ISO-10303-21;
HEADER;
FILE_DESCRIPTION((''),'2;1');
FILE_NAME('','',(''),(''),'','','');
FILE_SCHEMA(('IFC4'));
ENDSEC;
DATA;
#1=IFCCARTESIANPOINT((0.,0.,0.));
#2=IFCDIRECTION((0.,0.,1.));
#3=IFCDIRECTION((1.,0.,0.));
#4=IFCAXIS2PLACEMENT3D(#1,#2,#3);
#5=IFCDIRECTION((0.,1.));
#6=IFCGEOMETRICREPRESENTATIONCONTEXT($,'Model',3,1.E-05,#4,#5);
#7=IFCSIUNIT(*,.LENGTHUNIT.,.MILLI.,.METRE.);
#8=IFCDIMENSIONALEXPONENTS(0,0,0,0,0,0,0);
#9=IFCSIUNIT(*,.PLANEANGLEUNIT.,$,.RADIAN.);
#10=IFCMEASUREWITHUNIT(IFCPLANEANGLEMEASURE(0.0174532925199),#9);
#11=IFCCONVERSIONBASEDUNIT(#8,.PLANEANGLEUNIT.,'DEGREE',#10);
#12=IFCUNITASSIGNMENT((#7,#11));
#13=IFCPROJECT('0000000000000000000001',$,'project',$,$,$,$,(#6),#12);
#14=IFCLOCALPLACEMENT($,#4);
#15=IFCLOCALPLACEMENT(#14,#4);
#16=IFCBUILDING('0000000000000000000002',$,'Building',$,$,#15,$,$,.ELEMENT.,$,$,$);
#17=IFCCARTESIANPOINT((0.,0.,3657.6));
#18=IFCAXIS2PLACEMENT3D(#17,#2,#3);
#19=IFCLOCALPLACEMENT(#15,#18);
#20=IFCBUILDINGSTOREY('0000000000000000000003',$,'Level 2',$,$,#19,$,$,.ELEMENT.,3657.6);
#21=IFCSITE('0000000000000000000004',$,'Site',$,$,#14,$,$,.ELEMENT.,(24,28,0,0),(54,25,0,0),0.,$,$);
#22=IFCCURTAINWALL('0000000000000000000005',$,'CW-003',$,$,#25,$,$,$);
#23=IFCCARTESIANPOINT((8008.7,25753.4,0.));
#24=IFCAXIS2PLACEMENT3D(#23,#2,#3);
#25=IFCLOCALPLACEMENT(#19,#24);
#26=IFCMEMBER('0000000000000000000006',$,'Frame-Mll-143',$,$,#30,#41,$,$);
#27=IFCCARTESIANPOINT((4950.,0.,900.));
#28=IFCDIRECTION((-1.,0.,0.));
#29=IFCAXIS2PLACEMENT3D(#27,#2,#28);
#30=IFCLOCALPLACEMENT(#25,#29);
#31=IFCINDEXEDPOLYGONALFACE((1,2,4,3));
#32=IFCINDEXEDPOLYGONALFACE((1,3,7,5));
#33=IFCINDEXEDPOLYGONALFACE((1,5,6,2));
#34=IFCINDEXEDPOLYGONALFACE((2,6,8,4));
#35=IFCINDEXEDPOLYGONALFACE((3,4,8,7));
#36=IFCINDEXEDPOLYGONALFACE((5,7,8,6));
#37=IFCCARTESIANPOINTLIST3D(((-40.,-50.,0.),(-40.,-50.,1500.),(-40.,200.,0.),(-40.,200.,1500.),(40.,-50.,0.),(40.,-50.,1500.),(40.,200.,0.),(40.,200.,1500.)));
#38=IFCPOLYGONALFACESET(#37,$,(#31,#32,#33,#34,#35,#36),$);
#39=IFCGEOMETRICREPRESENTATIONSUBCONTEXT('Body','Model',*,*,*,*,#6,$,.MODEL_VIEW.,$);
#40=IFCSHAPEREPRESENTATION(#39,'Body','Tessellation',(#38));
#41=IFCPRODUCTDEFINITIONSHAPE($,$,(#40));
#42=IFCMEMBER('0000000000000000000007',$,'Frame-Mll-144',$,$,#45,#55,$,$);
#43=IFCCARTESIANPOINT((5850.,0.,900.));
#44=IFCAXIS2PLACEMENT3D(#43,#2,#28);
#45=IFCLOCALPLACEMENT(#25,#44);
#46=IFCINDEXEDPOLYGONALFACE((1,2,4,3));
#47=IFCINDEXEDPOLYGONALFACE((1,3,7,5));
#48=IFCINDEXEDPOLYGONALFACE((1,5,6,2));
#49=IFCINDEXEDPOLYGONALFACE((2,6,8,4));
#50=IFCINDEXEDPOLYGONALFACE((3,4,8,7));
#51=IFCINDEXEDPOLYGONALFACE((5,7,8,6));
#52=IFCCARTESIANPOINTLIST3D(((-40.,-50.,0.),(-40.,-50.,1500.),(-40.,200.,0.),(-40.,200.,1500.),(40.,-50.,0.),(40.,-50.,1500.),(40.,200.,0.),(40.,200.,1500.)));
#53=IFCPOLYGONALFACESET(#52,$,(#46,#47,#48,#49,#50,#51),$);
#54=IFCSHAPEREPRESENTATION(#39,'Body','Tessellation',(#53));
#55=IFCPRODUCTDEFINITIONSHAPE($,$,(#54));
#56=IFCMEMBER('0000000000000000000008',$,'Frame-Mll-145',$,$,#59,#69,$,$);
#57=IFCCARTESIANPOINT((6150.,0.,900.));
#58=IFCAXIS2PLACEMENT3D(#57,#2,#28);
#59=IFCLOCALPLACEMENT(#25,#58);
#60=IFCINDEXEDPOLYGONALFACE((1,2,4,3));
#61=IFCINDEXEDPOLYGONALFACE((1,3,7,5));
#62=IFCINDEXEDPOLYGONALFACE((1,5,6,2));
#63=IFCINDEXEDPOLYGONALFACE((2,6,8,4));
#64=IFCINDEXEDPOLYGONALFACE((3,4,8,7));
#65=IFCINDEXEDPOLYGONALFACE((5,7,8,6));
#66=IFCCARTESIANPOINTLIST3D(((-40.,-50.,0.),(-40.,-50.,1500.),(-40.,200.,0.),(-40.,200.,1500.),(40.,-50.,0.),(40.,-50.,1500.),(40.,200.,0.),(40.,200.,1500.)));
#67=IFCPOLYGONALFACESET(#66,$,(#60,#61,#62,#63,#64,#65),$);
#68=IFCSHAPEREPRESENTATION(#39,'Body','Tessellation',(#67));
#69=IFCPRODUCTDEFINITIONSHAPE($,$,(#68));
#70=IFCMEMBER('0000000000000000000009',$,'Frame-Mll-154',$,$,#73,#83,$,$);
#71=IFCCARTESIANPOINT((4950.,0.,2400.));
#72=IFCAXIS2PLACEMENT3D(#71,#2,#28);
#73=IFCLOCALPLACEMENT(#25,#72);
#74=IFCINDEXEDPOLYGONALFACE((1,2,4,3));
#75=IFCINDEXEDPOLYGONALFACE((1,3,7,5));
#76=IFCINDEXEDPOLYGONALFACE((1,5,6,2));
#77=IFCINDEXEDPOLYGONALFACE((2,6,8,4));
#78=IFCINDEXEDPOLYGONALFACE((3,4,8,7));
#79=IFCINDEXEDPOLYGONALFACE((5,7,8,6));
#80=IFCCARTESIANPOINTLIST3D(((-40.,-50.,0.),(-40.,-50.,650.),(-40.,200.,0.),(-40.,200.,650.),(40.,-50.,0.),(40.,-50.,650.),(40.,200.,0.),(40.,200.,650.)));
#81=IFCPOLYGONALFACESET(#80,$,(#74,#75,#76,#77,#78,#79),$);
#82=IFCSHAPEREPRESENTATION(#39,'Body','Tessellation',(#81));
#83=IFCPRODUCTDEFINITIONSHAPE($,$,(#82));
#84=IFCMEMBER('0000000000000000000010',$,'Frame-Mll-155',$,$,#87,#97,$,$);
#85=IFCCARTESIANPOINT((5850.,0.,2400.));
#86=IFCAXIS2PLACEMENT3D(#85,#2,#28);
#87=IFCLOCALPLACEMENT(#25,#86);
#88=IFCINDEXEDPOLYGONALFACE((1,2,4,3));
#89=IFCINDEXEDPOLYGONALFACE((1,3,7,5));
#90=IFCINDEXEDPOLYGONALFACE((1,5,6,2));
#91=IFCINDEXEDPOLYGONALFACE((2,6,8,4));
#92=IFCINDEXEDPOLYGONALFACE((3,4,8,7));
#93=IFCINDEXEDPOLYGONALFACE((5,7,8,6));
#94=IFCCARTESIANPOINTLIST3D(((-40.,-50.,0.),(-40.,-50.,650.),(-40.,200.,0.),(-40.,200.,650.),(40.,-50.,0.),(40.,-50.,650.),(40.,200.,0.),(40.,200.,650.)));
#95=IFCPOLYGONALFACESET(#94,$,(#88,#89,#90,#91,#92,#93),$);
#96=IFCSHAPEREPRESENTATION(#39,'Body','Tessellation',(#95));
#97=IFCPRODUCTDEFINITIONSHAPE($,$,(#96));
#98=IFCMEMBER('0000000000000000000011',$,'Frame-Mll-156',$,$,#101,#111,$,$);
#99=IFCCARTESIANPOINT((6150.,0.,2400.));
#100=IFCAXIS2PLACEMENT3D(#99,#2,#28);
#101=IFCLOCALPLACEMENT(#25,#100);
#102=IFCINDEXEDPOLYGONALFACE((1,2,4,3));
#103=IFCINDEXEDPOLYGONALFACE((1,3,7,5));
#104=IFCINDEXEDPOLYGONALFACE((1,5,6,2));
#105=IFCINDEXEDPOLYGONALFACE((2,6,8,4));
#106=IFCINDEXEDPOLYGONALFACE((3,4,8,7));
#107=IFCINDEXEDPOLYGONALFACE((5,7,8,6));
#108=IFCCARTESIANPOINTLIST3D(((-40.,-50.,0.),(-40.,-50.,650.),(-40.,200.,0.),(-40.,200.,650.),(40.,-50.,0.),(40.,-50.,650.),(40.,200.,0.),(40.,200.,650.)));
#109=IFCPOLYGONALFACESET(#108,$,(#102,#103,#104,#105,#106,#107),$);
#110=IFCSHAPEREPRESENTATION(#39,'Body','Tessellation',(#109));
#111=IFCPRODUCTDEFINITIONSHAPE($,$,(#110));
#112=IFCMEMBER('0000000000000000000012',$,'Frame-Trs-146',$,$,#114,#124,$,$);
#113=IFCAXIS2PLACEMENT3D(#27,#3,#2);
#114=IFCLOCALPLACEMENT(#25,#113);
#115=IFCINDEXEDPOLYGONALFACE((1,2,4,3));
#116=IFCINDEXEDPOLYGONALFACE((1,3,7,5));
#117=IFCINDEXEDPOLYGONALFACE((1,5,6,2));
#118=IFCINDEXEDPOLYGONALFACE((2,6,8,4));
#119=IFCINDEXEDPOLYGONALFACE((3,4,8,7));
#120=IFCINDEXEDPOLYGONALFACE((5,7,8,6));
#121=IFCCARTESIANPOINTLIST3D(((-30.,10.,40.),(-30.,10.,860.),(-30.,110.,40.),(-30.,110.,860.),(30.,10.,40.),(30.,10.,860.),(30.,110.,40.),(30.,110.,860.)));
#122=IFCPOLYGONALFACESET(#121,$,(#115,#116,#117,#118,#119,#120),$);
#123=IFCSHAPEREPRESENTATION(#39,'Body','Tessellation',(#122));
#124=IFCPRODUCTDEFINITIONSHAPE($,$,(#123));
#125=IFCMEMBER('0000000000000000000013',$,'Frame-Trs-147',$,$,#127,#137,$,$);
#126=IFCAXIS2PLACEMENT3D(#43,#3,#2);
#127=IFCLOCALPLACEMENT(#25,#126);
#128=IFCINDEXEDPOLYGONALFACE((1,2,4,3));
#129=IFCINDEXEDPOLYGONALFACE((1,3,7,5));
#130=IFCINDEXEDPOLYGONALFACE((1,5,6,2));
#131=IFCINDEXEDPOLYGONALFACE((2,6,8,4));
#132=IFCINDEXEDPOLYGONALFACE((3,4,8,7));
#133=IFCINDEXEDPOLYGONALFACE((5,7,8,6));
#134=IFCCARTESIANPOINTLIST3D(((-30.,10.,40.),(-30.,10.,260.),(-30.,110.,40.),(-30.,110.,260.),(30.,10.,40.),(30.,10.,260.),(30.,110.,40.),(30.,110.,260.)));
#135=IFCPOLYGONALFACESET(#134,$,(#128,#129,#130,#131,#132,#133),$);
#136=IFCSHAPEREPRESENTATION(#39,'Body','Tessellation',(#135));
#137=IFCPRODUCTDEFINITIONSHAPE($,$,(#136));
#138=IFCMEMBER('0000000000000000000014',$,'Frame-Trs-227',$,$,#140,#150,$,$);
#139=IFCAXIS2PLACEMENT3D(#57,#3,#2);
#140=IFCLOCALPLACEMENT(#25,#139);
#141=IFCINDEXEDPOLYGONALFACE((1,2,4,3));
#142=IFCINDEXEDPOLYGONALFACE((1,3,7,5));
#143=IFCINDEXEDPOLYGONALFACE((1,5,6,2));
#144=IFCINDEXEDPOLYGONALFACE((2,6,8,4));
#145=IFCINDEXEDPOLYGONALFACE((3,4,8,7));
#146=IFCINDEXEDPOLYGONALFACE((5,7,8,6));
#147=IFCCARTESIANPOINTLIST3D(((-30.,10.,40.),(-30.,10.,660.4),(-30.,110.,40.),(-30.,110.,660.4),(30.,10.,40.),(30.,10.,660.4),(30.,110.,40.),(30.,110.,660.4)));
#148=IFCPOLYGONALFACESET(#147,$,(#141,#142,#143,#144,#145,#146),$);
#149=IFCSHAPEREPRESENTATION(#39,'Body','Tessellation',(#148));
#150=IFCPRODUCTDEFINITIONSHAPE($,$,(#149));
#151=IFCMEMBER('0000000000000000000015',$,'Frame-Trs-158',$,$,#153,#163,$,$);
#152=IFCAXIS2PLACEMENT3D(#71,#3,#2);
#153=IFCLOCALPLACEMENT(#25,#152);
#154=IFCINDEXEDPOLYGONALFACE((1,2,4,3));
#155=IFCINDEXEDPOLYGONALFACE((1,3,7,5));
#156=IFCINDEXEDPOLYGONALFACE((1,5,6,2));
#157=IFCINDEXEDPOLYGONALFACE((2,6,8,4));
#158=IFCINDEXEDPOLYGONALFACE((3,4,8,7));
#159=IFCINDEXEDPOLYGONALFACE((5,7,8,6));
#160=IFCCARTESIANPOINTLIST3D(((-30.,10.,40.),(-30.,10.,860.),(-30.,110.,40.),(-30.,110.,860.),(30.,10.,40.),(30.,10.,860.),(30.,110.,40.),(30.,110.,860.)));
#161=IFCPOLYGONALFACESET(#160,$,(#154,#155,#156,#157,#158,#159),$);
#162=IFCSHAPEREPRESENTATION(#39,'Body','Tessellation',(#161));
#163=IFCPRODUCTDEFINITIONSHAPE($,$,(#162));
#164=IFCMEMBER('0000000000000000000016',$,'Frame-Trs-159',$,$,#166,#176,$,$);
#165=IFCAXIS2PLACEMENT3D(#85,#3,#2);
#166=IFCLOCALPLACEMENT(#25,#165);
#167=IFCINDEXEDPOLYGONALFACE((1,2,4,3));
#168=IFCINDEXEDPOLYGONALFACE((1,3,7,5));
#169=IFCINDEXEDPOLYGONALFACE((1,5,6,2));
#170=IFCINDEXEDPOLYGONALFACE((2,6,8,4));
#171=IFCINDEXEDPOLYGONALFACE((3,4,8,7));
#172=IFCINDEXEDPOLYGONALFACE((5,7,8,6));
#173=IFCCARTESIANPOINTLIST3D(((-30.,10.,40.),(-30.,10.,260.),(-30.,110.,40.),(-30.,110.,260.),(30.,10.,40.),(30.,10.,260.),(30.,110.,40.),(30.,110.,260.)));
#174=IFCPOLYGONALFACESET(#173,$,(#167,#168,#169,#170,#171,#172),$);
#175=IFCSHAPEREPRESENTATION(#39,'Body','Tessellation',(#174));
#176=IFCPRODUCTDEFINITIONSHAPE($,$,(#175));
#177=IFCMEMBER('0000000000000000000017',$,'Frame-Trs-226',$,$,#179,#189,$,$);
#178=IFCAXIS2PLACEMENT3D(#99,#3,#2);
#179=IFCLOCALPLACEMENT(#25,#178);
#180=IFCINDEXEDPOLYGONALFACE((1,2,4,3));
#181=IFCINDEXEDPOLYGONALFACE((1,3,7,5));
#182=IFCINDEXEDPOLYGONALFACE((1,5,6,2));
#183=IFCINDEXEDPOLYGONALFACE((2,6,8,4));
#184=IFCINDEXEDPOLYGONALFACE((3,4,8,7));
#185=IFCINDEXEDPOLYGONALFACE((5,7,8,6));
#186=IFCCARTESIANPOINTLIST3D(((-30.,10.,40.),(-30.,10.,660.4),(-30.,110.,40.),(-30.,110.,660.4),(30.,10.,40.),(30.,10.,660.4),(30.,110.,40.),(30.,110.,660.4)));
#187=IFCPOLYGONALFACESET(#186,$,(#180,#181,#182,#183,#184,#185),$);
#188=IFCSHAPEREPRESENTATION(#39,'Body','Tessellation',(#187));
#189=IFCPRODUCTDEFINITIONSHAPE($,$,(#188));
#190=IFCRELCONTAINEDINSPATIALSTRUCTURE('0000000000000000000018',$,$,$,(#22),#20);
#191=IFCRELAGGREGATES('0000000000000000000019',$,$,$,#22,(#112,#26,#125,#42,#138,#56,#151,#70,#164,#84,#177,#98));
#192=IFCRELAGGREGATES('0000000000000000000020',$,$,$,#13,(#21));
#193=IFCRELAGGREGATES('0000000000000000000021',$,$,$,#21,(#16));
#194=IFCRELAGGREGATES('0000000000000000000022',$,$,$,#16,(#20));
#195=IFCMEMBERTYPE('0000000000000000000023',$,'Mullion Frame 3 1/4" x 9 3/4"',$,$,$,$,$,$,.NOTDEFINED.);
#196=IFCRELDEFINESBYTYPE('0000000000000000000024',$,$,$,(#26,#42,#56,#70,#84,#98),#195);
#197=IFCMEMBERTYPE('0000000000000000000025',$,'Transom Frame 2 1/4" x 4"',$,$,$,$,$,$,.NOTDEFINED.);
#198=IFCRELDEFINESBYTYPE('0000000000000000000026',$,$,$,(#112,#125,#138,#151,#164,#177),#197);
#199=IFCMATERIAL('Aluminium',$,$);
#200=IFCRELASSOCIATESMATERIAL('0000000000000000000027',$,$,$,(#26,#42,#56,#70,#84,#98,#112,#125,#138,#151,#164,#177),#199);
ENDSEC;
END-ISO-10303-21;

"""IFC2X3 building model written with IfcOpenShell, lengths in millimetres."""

from ifc_helpers import new_model, entity, si_unit, converted_unit, direction, frame, origin_with_axes, place, context, subcontext, project, spatial, polyline, outline, extrude, material, type_object, element, aggregate, save


model = new_model("IFC2X3")

# Units and contexts
model_context = context("Model", 3, precision=1e-05, world=origin_with_axes(), true_north=direction((0.0, 1.0)))
body_context = subcontext(model_context, "Body", "Model", "MODEL_VIEW")
ifc_project = project(units=[si_unit("LENGTHUNIT", "METRE", prefix="MILLI"), converted_unit("PLANEANGLEUNIT", "DEGREE", entity("IfcPlaneAngleMeasure", 0.0174532925199), si_unit("PLANEANGLEUNIT", "RADIAN"), dimensions=[0, 0, 0, 0, 0, 0, 0])], contexts=[model_context])

# Site, building, storey
site_placement = place(None, origin_with_axes())
site = spatial("IfcSite", under=ifc_project, at=site_placement, Name="Site", CompositionType="ELEMENT", RefLatitude=(24, 28, 0, 0), RefLongitude=(54, 25, 0, 0), RefElevation=0.0)
building_placement = place(site_placement, origin_with_axes())
building = spatial("IfcBuilding", under=site, at=building_placement, Name="Building", CompositionType="ELEMENT")
storey_placement = place(building_placement, frame((0.0, 0.0, 3657.6), z_axis=(0.0, 0.0, 1.0), x_axis=(1.0, 0.0, 0.0)))
storey = spatial("IfcBuildingStorey", under=building, at=storey_placement, Name="Level 2", CompositionType="ELEMENT", Elevation=3657.6)

# Curtain wall, members
curtain_wall_placement = place(storey_placement, frame((8008.7, 25753.4, 0.0), z_axis=(0.0, 0.0, 1.0), x_axis=(1.0, 0.0, 0.0)))
curtain_wall = element("IfcCurtainWall", 1, at=curtain_wall_placement, inside=storey, Name="CW-003")
ifc_material_1 = material(Name="Aluminium")
member_type_1 = type_object("IfcMemberType", Name="Mullion Frame 3 1/4\" x 9 3/4\"", PredefinedType="NOTDEFINED")
member_1_placement = place(curtain_wall_placement, frame((4950.0, 0.0, 900.0), z_axis=(0.0, 0.0, 1.0), x_axis=(-1.0, 0.0, 0.0)))
member_1 = element("IfcMember", 2, at=member_1_placement, type_object=member_type_1, material=ifc_material_1, Name="Frame-Mll-143", context=body_context, shape_type="SweptSolid", body=[
    extrude(outline(polyline([(-40.0, -200.0), (40.0, -200.0), (40.0, 50.0), (-40.0, 50.0), (-40.0, -200.0)])), frame((0.0, 0.0, 0.0), z_axis=(0.0, 0.0, 1.0), x_axis=(-1.0, 0.0, 0.0)), (0.0, 0.0, 1.0), 1500.0),
])
member_2_placement = place(curtain_wall_placement, frame((5850.0, 0.0, 900.0), z_axis=(0.0, 0.0, 1.0), x_axis=(-1.0, 0.0, 0.0)))
member_2 = element("IfcMember", 3, at=member_2_placement, type_object=member_type_1, material=ifc_material_1, Name="Frame-Mll-144", context=body_context, shape_type="SweptSolid", body=[
    extrude(outline(polyline([(-40.0, -200.0), (40.0, -200.0), (40.0, 50.0), (-40.0, 50.0), (-40.0, -200.0)])), frame((0.0, 0.0, 0.0), z_axis=(0.0, 0.0, 1.0), x_axis=(-1.0, 0.0, 0.0)), (0.0, 0.0, 1.0), 1500.0),
])
member_3_placement = place(curtain_wall_placement, frame((6150.0, 0.0, 900.0), z_axis=(0.0, 0.0, 1.0), x_axis=(-1.0, 0.0, 0.0)))
member_3 = element("IfcMember", 4, at=member_3_placement, type_object=member_type_1, material=ifc_material_1, Name="Frame-Mll-145", context=body_context, shape_type="SweptSolid", body=[
    extrude(outline(polyline([(-40.0, -200.0), (40.0, -200.0), (40.0, 50.0), (-40.0, 50.0), (-40.0, -200.0)])), frame((0.0, 0.0, 0.0), z_axis=(0.0, 0.0, 1.0), x_axis=(-1.0, 0.0, 0.0)), (0.0, 0.0, 1.0), 1500.0),
])
member_4_placement = place(curtain_wall_placement, frame((4950.0, 0.0, 2400.0), z_axis=(0.0, 0.0, 1.0), x_axis=(-1.0, 0.0, 0.0)))
member_4 = element("IfcMember", 5, at=member_4_placement, type_object=member_type_1, material=ifc_material_1, Name="Frame-Mll-154", context=body_context, shape_type="SweptSolid", body=[
    extrude(outline(polyline([(-40.0, -200.0), (40.0, -200.0), (40.0, 50.0), (-40.0, 50.0), (-40.0, -200.0)])), frame((0.0, 0.0, 0.0), z_axis=(0.0, 0.0, 1.0), x_axis=(-1.0, 0.0, 0.0)), (0.0, 0.0, 1.0), 650.0),
])
member_5_placement = place(curtain_wall_placement, frame((5850.0, 0.0, 2400.0), z_axis=(0.0, 0.0, 1.0), x_axis=(-1.0, 0.0, 0.0)))
member_5 = element("IfcMember", 6, at=member_5_placement, type_object=member_type_1, material=ifc_material_1, Name="Frame-Mll-155", context=body_context, shape_type="SweptSolid", body=[
    extrude(outline(polyline([(-40.0, -200.0), (40.0, -200.0), (40.0, 50.0), (-40.0, 50.0), (-40.0, -200.0)])), frame((0.0, 0.0, 0.0), z_axis=(0.0, 0.0, 1.0), x_axis=(-1.0, 0.0, 0.0)), (0.0, 0.0, 1.0), 650.0),
])
member_6_placement = place(curtain_wall_placement, frame((6150.0, 0.0, 2400.0), z_axis=(0.0, 0.0, 1.0), x_axis=(-1.0, 0.0, 0.0)))
member_6 = element("IfcMember", 7, at=member_6_placement, type_object=member_type_1, material=ifc_material_1, Name="Frame-Mll-156", context=body_context, shape_type="SweptSolid", body=[
    extrude(outline(polyline([(-40.0, -200.0), (40.0, -200.0), (40.0, 50.0), (-40.0, 50.0), (-40.0, -200.0)])), frame((0.0, 0.0, 0.0), z_axis=(0.0, 0.0, 1.0), x_axis=(-1.0, 0.0, 0.0)), (0.0, 0.0, 1.0), 650.0),
])
member_type_2 = type_object("IfcMemberType", Name="Transom Frame 2 1/4\" x 4\"", PredefinedType="NOTDEFINED")
member_7_placement = place(curtain_wall_placement, frame((4950.0, 0.0, 900.0), z_axis=(1.0, 0.0, 0.0), x_axis=(0.0, 0.0, 1.0)))
member_7 = element("IfcMember", 8, at=member_7_placement, type_object=member_type_2, material=ifc_material_1, Name="Frame-Trs-146", context=body_context, shape_type="SweptSolid", body=[
    extrude(outline(polyline([(110.0, -30.0), (110.0, 30.0), (10.0, 30.0), (10.0, -30.0), (110.0, -30.0)])), frame((0.0, 0.0, 40.0), z_axis=(0.0, 0.0, 1.0), x_axis=(0.0, 1.0, 0.0)), (0.0, 0.0, 1.0), 820.0),
])
member_8_placement = place(curtain_wall_placement, frame((5850.0, 0.0, 900.0), z_axis=(1.0, 0.0, 0.0), x_axis=(0.0, 0.0, 1.0)))
member_8 = element("IfcMember", 9, at=member_8_placement, type_object=member_type_2, material=ifc_material_1, Name="Frame-Trs-147", context=body_context, shape_type="SweptSolid", body=[
    extrude(outline(polyline([(110.0, -30.0), (110.0, 30.0), (10.0, 30.0), (10.0, -30.0), (110.0, -30.0)])), frame((0.0, 0.0, 40.0), z_axis=(0.0, 0.0, 1.0), x_axis=(0.0, 1.0, 0.0)), (0.0, 0.0, 1.0), 220.0),
])
member_9_placement = place(curtain_wall_placement, frame((6150.0, 0.0, 900.0), z_axis=(1.0, 0.0, 0.0), x_axis=(0.0, 0.0, 1.0)))
member_9 = element("IfcMember", 10, at=member_9_placement, type_object=member_type_2, material=ifc_material_1, Name="Frame-Trs-227", context=body_context, shape_type="SweptSolid", body=[
    extrude(outline(polyline([(110.0, -30.0), (110.0, 30.0), (10.0, 30.0), (10.0, -30.0), (110.0, -30.0)])), frame((0.0, 0.0, 40.0), z_axis=(0.0, 0.0, 1.0), x_axis=(0.0, 1.0, 0.0)), (0.0, 0.0, 1.0), 620.4),
])
member_10_placement = place(curtain_wall_placement, frame((4950.0, 0.0, 2400.0), z_axis=(1.0, 0.0, 0.0), x_axis=(0.0, 0.0, 1.0)))
member_10 = element("IfcMember", 11, at=member_10_placement, type_object=member_type_2, material=ifc_material_1, Name="Frame-Trs-158", context=body_context, shape_type="SweptSolid", body=[
    extrude(outline(polyline([(110.0, -30.0), (110.0, 30.0), (10.0, 30.0), (10.0, -30.0), (110.0, -30.0)])), frame((0.0, 0.0, 40.0), z_axis=(0.0, 0.0, 1.0), x_axis=(0.0, 1.0, 0.0)), (0.0, 0.0, 1.0), 820.0),
])
member_11_placement = place(curtain_wall_placement, frame((5850.0, 0.0, 2400.0), z_axis=(1.0, 0.0, 0.0), x_axis=(0.0, 0.0, 1.0)))
member_11 = element("IfcMember", 12, at=member_11_placement, type_object=member_type_2, material=ifc_material_1, Name="Frame-Trs-159", context=body_context, shape_type="SweptSolid", body=[
    extrude(outline(polyline([(110.0, -30.0), (110.0, 30.0), (10.0, 30.0), (10.0, -30.0), (110.0, -30.0)])), frame((0.0, 0.0, 40.0), z_axis=(0.0, 0.0, 1.0), x_axis=(0.0, 1.0, 0.0)), (0.0, 0.0, 1.0), 220.0),
])
member_12_placement = place(curtain_wall_placement, frame((6150.0, 0.0, 2400.0), z_axis=(1.0, 0.0, 0.0), x_axis=(0.0, 0.0, 1.0)))
member_12 = element("IfcMember", 13, at=member_12_placement, type_object=member_type_2, material=ifc_material_1, Name="Frame-Trs-226", context=body_context, shape_type="SweptSolid", body=[
    extrude(outline(polyline([(110.0, -30.0), (110.0, 30.0), (10.0, 30.0), (10.0, -30.0), (110.0, -30.0)])), frame((0.0, 0.0, 40.0), z_axis=(0.0, 0.0, 1.0), x_axis=(0.0, 1.0, 0.0)), (0.0, 0.0, 1.0), 620.4),
])

aggregate(curtain_wall, [member_7, member_1, member_8, member_2, member_9, member_3, member_10, member_4, member_11, member_5, member_12, member_6])

save(model, "model.ifc")
